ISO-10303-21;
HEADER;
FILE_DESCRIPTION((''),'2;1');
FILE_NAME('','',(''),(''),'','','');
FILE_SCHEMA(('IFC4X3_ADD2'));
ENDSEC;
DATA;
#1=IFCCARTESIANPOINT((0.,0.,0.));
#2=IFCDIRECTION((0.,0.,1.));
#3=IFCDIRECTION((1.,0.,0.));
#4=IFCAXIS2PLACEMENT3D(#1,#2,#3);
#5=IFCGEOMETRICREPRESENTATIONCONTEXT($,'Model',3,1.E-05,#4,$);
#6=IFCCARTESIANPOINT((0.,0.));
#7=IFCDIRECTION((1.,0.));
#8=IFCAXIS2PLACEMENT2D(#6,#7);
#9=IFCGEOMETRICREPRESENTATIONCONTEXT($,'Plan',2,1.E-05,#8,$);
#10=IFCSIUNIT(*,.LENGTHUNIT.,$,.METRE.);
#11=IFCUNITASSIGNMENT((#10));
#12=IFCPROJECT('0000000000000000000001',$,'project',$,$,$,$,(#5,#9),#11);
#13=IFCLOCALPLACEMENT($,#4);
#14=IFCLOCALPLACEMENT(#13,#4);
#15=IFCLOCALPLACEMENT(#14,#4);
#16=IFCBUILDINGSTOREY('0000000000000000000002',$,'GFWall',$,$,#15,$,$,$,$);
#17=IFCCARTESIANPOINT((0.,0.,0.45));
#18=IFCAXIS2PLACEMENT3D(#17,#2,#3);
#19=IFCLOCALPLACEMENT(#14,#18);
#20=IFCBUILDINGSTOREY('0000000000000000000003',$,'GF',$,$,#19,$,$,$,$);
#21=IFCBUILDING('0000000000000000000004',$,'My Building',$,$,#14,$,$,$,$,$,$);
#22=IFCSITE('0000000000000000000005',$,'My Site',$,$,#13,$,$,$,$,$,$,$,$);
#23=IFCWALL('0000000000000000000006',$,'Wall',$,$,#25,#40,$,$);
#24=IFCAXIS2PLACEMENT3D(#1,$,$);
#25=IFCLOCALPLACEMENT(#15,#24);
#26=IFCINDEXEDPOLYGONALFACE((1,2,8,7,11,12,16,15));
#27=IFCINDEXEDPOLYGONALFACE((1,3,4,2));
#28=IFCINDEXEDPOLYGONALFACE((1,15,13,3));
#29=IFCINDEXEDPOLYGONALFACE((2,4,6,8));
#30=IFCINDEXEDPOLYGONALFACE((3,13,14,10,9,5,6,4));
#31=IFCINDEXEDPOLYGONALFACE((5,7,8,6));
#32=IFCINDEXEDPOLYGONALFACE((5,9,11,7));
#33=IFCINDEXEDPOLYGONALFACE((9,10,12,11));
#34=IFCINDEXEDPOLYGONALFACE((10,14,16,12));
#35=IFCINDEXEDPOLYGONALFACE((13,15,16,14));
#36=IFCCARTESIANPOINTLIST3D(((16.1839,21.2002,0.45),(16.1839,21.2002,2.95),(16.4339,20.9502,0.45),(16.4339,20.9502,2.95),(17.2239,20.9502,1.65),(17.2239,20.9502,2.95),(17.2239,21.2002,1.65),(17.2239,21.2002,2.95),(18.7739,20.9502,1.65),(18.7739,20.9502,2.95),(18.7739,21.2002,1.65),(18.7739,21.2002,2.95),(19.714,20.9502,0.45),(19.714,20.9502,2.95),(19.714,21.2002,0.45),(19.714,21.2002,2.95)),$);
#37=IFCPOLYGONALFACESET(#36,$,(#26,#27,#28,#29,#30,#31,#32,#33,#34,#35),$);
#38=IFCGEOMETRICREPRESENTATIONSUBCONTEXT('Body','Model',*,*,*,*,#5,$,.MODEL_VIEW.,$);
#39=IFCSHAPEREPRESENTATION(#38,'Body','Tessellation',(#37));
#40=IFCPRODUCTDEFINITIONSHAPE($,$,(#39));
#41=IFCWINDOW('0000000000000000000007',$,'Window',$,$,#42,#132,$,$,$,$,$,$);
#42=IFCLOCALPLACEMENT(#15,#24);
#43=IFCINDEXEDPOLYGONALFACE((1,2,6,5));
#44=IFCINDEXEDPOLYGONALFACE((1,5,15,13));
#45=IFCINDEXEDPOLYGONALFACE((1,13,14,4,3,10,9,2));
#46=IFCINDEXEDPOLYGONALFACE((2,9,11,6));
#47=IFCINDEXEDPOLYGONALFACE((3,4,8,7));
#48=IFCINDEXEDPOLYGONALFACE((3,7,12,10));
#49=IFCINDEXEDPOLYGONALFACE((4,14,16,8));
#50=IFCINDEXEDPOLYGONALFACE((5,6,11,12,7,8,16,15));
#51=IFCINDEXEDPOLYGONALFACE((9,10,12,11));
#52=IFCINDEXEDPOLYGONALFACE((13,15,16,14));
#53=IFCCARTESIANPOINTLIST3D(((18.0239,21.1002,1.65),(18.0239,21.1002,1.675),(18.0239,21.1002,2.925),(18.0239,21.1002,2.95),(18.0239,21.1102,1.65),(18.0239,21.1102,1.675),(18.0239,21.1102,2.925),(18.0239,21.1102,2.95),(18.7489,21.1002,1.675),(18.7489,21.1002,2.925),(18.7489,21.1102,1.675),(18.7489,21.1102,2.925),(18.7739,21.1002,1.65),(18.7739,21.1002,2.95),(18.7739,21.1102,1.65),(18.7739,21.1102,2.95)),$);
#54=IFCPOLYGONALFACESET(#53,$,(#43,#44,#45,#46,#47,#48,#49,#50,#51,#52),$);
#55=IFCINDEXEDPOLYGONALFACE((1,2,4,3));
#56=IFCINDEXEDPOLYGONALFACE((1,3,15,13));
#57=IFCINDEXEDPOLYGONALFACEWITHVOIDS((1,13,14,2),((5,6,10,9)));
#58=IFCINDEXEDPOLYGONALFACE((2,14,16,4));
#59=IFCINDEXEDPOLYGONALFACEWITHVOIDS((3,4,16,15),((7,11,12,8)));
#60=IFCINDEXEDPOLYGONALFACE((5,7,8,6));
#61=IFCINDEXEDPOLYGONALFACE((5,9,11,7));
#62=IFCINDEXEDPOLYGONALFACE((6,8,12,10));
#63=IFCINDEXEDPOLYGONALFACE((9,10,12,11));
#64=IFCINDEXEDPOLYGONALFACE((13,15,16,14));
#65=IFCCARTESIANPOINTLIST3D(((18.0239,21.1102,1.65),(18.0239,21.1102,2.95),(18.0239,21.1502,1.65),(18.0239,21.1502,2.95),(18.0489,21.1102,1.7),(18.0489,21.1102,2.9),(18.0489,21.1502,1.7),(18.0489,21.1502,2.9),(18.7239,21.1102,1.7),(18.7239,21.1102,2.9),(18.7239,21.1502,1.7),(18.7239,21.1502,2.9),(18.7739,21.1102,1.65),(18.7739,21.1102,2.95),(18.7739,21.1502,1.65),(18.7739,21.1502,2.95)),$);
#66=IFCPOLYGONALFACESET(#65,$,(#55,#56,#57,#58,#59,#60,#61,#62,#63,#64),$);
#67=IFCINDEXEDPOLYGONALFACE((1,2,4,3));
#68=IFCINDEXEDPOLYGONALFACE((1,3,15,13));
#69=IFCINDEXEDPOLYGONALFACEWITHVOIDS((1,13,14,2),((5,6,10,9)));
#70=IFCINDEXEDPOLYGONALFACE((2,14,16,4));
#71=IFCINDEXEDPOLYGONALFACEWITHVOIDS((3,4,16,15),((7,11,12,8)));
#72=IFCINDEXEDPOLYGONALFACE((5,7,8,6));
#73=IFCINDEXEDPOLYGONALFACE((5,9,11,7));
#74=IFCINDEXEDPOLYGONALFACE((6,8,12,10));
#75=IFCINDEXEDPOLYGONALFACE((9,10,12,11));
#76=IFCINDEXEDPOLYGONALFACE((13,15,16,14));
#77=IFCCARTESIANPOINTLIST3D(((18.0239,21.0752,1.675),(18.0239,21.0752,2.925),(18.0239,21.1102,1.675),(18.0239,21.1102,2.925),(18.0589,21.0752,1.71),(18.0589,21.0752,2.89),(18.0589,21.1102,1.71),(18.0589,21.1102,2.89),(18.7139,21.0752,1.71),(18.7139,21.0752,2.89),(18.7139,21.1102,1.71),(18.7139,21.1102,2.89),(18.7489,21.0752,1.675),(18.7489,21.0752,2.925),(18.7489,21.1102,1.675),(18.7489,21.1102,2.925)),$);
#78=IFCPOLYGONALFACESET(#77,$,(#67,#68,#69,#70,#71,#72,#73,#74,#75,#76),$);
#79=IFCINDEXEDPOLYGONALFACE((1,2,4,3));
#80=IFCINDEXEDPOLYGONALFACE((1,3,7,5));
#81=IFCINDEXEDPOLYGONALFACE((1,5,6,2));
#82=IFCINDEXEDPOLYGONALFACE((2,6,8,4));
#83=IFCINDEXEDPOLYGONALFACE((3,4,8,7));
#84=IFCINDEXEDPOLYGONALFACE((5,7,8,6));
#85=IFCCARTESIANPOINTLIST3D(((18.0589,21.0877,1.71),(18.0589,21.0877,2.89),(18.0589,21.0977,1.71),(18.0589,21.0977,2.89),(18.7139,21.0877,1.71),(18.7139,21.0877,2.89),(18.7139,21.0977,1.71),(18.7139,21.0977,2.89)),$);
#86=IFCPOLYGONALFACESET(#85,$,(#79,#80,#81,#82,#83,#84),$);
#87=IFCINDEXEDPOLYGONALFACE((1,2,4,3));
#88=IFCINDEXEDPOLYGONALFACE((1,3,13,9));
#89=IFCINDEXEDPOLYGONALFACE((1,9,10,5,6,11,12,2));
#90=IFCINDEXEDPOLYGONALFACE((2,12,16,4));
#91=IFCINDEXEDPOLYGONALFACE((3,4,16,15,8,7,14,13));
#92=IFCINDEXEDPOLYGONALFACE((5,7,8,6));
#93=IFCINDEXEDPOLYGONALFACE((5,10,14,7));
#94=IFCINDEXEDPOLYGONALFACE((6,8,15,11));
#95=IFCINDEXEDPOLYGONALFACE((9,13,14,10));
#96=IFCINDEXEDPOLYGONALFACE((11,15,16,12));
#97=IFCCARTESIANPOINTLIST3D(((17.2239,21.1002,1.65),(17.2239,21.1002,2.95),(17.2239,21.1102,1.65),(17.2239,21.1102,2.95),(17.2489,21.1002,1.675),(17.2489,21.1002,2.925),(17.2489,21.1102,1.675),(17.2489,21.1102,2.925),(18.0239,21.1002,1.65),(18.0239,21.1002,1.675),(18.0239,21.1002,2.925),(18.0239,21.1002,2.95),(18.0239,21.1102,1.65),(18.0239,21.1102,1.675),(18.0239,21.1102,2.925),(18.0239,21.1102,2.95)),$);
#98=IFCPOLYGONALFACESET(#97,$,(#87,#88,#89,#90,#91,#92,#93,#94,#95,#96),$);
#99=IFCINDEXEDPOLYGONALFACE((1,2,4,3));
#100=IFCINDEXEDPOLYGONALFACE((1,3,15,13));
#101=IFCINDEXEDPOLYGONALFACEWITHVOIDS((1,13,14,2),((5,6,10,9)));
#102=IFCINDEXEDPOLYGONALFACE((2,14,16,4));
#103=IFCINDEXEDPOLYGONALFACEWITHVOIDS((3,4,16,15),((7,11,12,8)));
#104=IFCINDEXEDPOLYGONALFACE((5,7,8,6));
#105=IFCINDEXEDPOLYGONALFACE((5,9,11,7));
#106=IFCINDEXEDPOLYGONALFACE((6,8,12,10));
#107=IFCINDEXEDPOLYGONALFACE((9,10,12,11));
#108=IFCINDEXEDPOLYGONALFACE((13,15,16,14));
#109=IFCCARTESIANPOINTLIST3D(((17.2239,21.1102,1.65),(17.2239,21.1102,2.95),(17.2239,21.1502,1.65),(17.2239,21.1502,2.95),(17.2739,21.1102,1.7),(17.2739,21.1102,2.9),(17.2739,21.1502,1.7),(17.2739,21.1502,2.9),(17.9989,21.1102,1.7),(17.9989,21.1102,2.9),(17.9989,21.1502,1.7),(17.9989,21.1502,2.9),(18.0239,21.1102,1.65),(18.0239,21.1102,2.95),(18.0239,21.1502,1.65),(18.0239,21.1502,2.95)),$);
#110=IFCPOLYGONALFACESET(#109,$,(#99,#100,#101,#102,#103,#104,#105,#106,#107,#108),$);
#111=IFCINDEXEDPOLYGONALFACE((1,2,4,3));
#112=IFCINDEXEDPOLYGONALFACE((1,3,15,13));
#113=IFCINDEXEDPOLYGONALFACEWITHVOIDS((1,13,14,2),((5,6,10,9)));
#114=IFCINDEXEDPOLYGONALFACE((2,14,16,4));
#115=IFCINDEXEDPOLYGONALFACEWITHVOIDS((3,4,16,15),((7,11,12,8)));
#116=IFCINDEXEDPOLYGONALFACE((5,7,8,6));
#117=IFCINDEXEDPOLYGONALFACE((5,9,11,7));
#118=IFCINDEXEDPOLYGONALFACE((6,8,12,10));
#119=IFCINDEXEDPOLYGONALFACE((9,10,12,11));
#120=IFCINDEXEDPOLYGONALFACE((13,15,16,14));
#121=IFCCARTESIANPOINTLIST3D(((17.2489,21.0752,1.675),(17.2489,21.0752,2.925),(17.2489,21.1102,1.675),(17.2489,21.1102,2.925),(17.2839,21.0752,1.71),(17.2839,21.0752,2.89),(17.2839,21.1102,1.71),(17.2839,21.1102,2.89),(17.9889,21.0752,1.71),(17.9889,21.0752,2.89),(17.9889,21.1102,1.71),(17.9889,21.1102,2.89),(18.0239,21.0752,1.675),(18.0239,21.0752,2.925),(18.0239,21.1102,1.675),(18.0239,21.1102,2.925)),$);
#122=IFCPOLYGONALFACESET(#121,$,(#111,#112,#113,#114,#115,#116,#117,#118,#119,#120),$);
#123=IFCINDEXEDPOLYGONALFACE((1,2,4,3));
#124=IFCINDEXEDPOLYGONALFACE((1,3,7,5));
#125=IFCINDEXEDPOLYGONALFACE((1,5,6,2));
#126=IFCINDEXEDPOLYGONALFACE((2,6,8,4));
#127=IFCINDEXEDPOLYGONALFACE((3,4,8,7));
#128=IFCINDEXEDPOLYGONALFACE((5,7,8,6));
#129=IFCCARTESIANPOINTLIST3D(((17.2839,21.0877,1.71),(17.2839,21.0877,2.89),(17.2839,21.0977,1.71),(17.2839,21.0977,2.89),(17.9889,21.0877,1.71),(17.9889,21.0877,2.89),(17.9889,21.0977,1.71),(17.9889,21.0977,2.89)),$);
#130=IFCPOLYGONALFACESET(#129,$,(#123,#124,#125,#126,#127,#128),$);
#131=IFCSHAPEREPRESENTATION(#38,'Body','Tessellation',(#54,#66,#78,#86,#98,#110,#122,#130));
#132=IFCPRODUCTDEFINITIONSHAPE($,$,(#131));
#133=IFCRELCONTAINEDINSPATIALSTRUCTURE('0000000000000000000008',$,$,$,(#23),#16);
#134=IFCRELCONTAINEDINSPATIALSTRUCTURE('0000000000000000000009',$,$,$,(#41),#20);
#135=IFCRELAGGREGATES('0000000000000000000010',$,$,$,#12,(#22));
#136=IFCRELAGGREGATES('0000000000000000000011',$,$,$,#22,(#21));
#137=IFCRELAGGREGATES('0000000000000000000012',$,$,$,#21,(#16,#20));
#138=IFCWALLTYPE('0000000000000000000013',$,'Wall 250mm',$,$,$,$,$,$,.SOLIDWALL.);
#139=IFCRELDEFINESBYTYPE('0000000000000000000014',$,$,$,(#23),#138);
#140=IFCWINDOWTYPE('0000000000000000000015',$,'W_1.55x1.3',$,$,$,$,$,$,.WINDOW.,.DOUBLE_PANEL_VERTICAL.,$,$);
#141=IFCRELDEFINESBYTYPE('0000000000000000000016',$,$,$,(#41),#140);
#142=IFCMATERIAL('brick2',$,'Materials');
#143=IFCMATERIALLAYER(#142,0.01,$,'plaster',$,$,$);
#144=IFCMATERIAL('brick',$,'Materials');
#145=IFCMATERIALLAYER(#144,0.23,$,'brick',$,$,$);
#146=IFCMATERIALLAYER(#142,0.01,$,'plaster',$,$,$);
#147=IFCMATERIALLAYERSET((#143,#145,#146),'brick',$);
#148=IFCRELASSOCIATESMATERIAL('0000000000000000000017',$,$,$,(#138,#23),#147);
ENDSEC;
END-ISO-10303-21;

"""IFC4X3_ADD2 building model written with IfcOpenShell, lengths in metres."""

from ifc_helpers import new_model, entity, si_unit, frame, origin_with_axes, origin_2d_with_axis, place, context, subcontext, project, spatial, line, indexed_curve, outline, extrude, shape, source, transform, mapped, material, layer, layer_set, layer_usage, type_object, type_shapes, element, fill, save


model = new_model("IFC4X3_ADD2")

# Units and contexts
model_context = context("Model", 3, precision=1e-05, world=origin_with_axes())
plan_context = context("Plan", 2, precision=1e-05, world=origin_2d_with_axis())
body_context_1 = subcontext(model_context, "Body", "Model", "MODEL_VIEW")
body_context_2 = subcontext(plan_context, "Body", "Plan", "PLAN_VIEW")
ifc_project = project(units=[si_unit("LENGTHUNIT", "METRE")], contexts=[model_context, plan_context])

# Site, building, storey
site_placement = place(None, origin_with_axes())
site = spatial("IfcSite", under=ifc_project, at=site_placement, Name="My Site")
building_placement = place(site_placement, origin_with_axes())
building = spatial("IfcBuilding", under=site, at=building_placement, Name="My Building")
storey_1_placement = place(building_placement, origin_with_axes())
storey_1 = spatial("IfcBuildingStorey", under=building, at=storey_1_placement, Name="GFWall")

# Wall, opening
ifc_material_1 = material(Name="brick2", Category="Materials")
ifc_layer_1 = layer(ifc_material_1, 0.01, Name="plaster")
ifc_material_2 = material(Name="brick", Category="Materials")
ifc_layer_2 = layer(ifc_material_2, 0.23, Name="brick")
ifc_layer_3 = layer(ifc_material_1, 0.01, Name="plaster")
ifc_layer_set_1 = layer_set([ifc_layer_1, ifc_layer_2, ifc_layer_3], Name="brick")
ifc_layer_usage_1 = layer_usage(ifc_layer_set_1, "AXIS2", "POSITIVE", 0.0)
wall_type_1 = type_object("IfcWallType", Name="Wall 250mm", PredefinedType="SOLIDWALL", material=ifc_layer_set_1)
wall_1_placement = place(storey_1_placement, frame((19.714, 21.2002, 0.45), z_axis=(0.0, 0.0, 1.0), x_axis=(-1.0, 0.0, 0.0)))
wall_1 = element("IfcWall", 1, at=wall_1_placement, inside=storey_1, type_object=wall_type_1, material=ifc_layer_usage_1, Name="Wall", context=body_context_1, shape_type="SweptSolid", body=[
    extrude(outline(indexed_curve([(0.0, 0.0), (0.0, 0.25), (3.28, 0.25), (3.53, 0.0)], segments=[line(1, 2, 3, 4, 1)])), origin_with_axes(), (0.0, 0.0, 1.0), 2.5),
])
shared_shape_1 = source(origin_with_axes(), body_context_1, "Body", "SweptSolid", [
    extrude(outline(indexed_curve([(0.0, 0.0), (1.55, 0.0), (1.55, 1.3), (0.0, 1.3)], segments=[line(1, 2, 3, 4, 1)])), frame((0.0, -0.6, 0.0), z_axis=(0.0, -1.0, 0.0), x_axis=(1.0, 0.0, 0.0)), (0.0, 0.0, -1.0), 1.2),
])
opening_1_placement = place(wall_1_placement, frame((0.9401, 0.0, 1.2), z_axis=(0.0, 0.0, 1.0), x_axis=(1.0, 0.0, 0.0)))
opening_1 = element("IfcOpeningElement", 2, at=opening_1_placement, cuts=wall_1, PredefinedType="OPENING", context=body_context_1, shape_type="MappedRepresentation", body=[
    mapped(shared_shape_1, transform((0.0, 0.0, 0.0), x_axis=(1.0, 0.0, 0.0), y_axis=(0.0, 1.0, 0.0), z_axis=(0.0, 0.0, 1.0), scale=1.0)),
])

# Shared definitions
storey_2_placement = place(building_placement, frame((0.0, 0.0, 0.45), z_axis=(0.0, 0.0, 1.0), x_axis=(1.0, 0.0, 0.0)))
storey_2 = spatial("IfcBuildingStorey", under=building, at=storey_2_placement, Name="GF")

# Window
window_type = type_object("IfcWindowType", Name="W_1.55x1.3", PartitioningType="DOUBLE_PANEL_VERTICAL", PredefinedType="WINDOW")
shared_shape_2 = source(origin_with_axes(), body_context_1, "Body", "SweptSolid", [
    extrude(outline(indexed_curve([(0.75, 0.0), (0.0, 0.0), (0.0, 1.3), (0.75, 1.3), (0.75, 1.275), (0.025, 1.275), (0.025, 0.025), (0.75, 0.025)], segments=[line(1, 2, 3, 4, 5, 6, 7, 8, 1)])), frame((0.0, 0.09, 0.0), z_axis=(0.0, -1.0, 0.0), x_axis=(1.0, 0.0, 0.0)), (0.0, 0.0, -1.0), 0.01),
    extrude(outline(indexed_curve([(0.0, 0.0), (0.75, 0.0), (0.75, 1.3), (0.0, 1.3)], segments=[line(1, 2, 3, 4, 1)]), holes=[indexed_curve([(0.05, 0.05), (0.725, 0.05), (0.725, 1.25), (0.05, 1.25)], segments=[line(1, 2, 3, 4, 1)])]), frame((0.0, 0.05, 0.0), z_axis=(0.0, -1.0, 0.0), x_axis=(1.0, 0.0, 0.0)), (0.0, 0.0, -1.0), 0.04),
    extrude(outline(indexed_curve([(0.0, 0.0), (0.725, 0.0), (0.725, 1.25), (0.0, 1.25)], segments=[line(1, 2, 3, 4, 1)]), holes=[indexed_curve([(0.035, 0.035), (0.69, 0.035), (0.69, 1.215), (0.035, 1.215)], segments=[line(1, 2, 3, 4, 1)])]), frame((0.025, 0.09, 0.025), z_axis=(0.0, -1.0, 0.0), x_axis=(1.0, 0.0, 0.0)), (0.0, 0.0, -1.0), 0.035),
    extrude(outline(indexed_curve([(0.035, 0.035), (0.69, 0.035), (0.69, 1.215), (0.035, 1.215)], segments=[line(1, 2, 3, 4, 1)])), frame((0.025, 0.1025, 0.025), z_axis=(0.0, -1.0, 0.0), x_axis=(1.0, 0.0, 0.0)), (0.0, 0.0, -1.0), 0.01),
    extrude(outline(indexed_curve([(0.0, 1.3), (0.8, 1.3), (0.8, 0.0), (0.0, 0.0), (0.0, 0.025), (0.775, 0.025), (0.775, 1.275), (0.0, 1.275)], segments=[line(1, 2, 3, 4, 5, 6, 7, 8, 1)])), frame((0.75, 0.09, 0.0), z_axis=(0.0, -1.0, 0.0), x_axis=(1.0, 0.0, 0.0)), (0.0, 0.0, -1.0), 0.01),
    extrude(outline(indexed_curve([(0.0, 0.0), (0.8, 0.0), (0.8, 1.3), (0.0, 1.3)], segments=[line(1, 2, 3, 4, 1)]), holes=[indexed_curve([(0.025, 0.05), (0.75, 0.05), (0.75, 1.25), (0.025, 1.25)], segments=[line(1, 2, 3, 4, 1)])]), frame((0.75, 0.05, 0.0), z_axis=(0.0, -1.0, 0.0), x_axis=(1.0, 0.0, 0.0)), (0.0, 0.0, -1.0), 0.04),
    extrude(outline(indexed_curve([(0.0, 0.0), (0.775, 0.0), (0.775, 1.25), (0.0, 1.25)], segments=[line(1, 2, 3, 4, 1)]), holes=[indexed_curve([(0.035, 0.035), (0.74, 0.035), (0.74, 1.215), (0.035, 1.215)], segments=[line(1, 2, 3, 4, 1)])]), frame((0.75, 0.09, 0.025), z_axis=(0.0, -1.0, 0.0), x_axis=(1.0, 0.0, 0.0)), (0.0, 0.0, -1.0), 0.035),
    extrude(outline(indexed_curve([(0.035, 0.035), (0.74, 0.035), (0.74, 1.215), (0.035, 1.215)], segments=[line(1, 2, 3, 4, 1)])), frame((0.75, 0.1025, 0.025), z_axis=(0.0, -1.0, 0.0), x_axis=(1.0, 0.0, 0.0)), (0.0, 0.0, -1.0), 0.01),
])
shared_shape_3 = source(origin_with_axes(), body_context_2, "Body", "Curve2D", [
    entity("IfcIndexedPolyCurve", entity("IfcCartesianPointList2D", [[0.05, 0.05], [0.725, 0.05]])),
    entity("IfcIndexedPolyCurve", entity("IfcCartesianPointList2D", [[0.0, 0.1], [0.025, 0.1], [0.025, 0.09], [0.05, 0.09], [0.05, 0.05], [0.0, 0.05]]), [entity("IfcLineIndex", [1, 2, 3, 4, 5, 6, 1])]),
    entity("IfcIndexedPolyCurve", entity("IfcCartesianPointList2D", [[0.75, 0.1], [0.75, 0.1], [0.75, 0.09], [0.725, 0.09], [0.725, 0.05], [0.75, 0.05]])),
    entity("IfcIndexedPolyCurve", entity("IfcCartesianPointList2D", [[0.025, 0.09], [0.06, 0.09], [0.06, 0.125], [0.025, 0.125]]), [entity("IfcLineIndex", [1, 2, 3, 4, 1])]),
    entity("IfcIndexedPolyCurve", entity("IfcCartesianPointList2D", [[0.75, 0.09], [0.715, 0.09], [0.715, 0.125], [0.75, 0.125]]), [entity("IfcLineIndex", [1, 2, 3, 4, 1])]),
    entity("IfcIndexedPolyCurve", entity("IfcCartesianPointList2D", [[0.06, 0.09], [0.715, 0.09]])),
    entity("IfcIndexedPolyCurve", entity("IfcCartesianPointList2D", [[0.06, 0.125], [0.715, 0.125]])),
    entity("IfcIndexedPolyCurve", entity("IfcCartesianPointList2D", [[0.06, 0.1075], [0.715, 0.1075]])),
    entity("IfcIndexedPolyCurve", entity("IfcCartesianPointList2D", [[0.775, 0.05], [1.5, 0.05]])),
    entity("IfcIndexedPolyCurve", entity("IfcCartesianPointList2D", [[0.75, 0.1], [0.75, 0.1], [0.75, 0.09], [0.775, 0.09], [0.775, 0.05], [0.75, 0.05]])),
    entity("IfcIndexedPolyCurve", entity("IfcCartesianPointList2D", [[1.55, 0.1], [1.525, 0.1], [1.525, 0.09], [1.5, 0.09], [1.5, 0.05], [1.55, 0.05]]), [entity("IfcLineIndex", [1, 2, 3, 4, 5, 6, 1])]),
    entity("IfcIndexedPolyCurve", entity("IfcCartesianPointList2D", [[0.75, 0.09], [0.785, 0.09], [0.785, 0.125], [0.75, 0.125]]), [entity("IfcLineIndex", [1, 2, 3, 4, 1])]),
    entity("IfcIndexedPolyCurve", entity("IfcCartesianPointList2D", [[1.525, 0.09], [1.49, 0.09], [1.49, 0.125], [1.525, 0.125]]), [entity("IfcLineIndex", [1, 2, 3, 4, 1])]),
    entity("IfcIndexedPolyCurve", entity("IfcCartesianPointList2D", [[0.785, 0.09], [1.49, 0.09]])),
    entity("IfcIndexedPolyCurve", entity("IfcCartesianPointList2D", [[0.785, 0.125], [1.49, 0.125]])),
    entity("IfcIndexedPolyCurve", entity("IfcCartesianPointList2D", [[0.785, 0.1075], [1.49, 0.1075]])),
])
type_shapes(window_type, [shared_shape_2, shared_shape_3])
window_1_placement = place(opening_1_placement, frame((0.0, 0.0, 0.0), z_axis=(0.0, 0.0, 1.0), x_axis=(1.0, 0.0, 0.0)))
window_1 = element("IfcWindow", 3, at=window_1_placement, inside=storey_2, type_object=window_type, Name="Window", shapes=[
    shape(body_context_1, "Body", "MappedRepresentation", [mapped(shared_shape_2, transform((0.0, 0.0, 0.0), x_axis=(1.0, 0.0, 0.0), y_axis=(0.0, 1.0, 0.0), z_axis=(0.0, 0.0, 1.0), scale=1.0))]),
    shape(body_context_2, "Body", "MappedRepresentation", [mapped(shared_shape_3, transform((0.0, 0.0, 0.0), x_axis=(1.0, 0.0, 0.0), y_axis=(0.0, 1.0, 0.0), z_axis=(0.0, 0.0, 1.0), scale=1.0))]),
])
fill(opening_1, window_1)

save(model, "model.ifc")
